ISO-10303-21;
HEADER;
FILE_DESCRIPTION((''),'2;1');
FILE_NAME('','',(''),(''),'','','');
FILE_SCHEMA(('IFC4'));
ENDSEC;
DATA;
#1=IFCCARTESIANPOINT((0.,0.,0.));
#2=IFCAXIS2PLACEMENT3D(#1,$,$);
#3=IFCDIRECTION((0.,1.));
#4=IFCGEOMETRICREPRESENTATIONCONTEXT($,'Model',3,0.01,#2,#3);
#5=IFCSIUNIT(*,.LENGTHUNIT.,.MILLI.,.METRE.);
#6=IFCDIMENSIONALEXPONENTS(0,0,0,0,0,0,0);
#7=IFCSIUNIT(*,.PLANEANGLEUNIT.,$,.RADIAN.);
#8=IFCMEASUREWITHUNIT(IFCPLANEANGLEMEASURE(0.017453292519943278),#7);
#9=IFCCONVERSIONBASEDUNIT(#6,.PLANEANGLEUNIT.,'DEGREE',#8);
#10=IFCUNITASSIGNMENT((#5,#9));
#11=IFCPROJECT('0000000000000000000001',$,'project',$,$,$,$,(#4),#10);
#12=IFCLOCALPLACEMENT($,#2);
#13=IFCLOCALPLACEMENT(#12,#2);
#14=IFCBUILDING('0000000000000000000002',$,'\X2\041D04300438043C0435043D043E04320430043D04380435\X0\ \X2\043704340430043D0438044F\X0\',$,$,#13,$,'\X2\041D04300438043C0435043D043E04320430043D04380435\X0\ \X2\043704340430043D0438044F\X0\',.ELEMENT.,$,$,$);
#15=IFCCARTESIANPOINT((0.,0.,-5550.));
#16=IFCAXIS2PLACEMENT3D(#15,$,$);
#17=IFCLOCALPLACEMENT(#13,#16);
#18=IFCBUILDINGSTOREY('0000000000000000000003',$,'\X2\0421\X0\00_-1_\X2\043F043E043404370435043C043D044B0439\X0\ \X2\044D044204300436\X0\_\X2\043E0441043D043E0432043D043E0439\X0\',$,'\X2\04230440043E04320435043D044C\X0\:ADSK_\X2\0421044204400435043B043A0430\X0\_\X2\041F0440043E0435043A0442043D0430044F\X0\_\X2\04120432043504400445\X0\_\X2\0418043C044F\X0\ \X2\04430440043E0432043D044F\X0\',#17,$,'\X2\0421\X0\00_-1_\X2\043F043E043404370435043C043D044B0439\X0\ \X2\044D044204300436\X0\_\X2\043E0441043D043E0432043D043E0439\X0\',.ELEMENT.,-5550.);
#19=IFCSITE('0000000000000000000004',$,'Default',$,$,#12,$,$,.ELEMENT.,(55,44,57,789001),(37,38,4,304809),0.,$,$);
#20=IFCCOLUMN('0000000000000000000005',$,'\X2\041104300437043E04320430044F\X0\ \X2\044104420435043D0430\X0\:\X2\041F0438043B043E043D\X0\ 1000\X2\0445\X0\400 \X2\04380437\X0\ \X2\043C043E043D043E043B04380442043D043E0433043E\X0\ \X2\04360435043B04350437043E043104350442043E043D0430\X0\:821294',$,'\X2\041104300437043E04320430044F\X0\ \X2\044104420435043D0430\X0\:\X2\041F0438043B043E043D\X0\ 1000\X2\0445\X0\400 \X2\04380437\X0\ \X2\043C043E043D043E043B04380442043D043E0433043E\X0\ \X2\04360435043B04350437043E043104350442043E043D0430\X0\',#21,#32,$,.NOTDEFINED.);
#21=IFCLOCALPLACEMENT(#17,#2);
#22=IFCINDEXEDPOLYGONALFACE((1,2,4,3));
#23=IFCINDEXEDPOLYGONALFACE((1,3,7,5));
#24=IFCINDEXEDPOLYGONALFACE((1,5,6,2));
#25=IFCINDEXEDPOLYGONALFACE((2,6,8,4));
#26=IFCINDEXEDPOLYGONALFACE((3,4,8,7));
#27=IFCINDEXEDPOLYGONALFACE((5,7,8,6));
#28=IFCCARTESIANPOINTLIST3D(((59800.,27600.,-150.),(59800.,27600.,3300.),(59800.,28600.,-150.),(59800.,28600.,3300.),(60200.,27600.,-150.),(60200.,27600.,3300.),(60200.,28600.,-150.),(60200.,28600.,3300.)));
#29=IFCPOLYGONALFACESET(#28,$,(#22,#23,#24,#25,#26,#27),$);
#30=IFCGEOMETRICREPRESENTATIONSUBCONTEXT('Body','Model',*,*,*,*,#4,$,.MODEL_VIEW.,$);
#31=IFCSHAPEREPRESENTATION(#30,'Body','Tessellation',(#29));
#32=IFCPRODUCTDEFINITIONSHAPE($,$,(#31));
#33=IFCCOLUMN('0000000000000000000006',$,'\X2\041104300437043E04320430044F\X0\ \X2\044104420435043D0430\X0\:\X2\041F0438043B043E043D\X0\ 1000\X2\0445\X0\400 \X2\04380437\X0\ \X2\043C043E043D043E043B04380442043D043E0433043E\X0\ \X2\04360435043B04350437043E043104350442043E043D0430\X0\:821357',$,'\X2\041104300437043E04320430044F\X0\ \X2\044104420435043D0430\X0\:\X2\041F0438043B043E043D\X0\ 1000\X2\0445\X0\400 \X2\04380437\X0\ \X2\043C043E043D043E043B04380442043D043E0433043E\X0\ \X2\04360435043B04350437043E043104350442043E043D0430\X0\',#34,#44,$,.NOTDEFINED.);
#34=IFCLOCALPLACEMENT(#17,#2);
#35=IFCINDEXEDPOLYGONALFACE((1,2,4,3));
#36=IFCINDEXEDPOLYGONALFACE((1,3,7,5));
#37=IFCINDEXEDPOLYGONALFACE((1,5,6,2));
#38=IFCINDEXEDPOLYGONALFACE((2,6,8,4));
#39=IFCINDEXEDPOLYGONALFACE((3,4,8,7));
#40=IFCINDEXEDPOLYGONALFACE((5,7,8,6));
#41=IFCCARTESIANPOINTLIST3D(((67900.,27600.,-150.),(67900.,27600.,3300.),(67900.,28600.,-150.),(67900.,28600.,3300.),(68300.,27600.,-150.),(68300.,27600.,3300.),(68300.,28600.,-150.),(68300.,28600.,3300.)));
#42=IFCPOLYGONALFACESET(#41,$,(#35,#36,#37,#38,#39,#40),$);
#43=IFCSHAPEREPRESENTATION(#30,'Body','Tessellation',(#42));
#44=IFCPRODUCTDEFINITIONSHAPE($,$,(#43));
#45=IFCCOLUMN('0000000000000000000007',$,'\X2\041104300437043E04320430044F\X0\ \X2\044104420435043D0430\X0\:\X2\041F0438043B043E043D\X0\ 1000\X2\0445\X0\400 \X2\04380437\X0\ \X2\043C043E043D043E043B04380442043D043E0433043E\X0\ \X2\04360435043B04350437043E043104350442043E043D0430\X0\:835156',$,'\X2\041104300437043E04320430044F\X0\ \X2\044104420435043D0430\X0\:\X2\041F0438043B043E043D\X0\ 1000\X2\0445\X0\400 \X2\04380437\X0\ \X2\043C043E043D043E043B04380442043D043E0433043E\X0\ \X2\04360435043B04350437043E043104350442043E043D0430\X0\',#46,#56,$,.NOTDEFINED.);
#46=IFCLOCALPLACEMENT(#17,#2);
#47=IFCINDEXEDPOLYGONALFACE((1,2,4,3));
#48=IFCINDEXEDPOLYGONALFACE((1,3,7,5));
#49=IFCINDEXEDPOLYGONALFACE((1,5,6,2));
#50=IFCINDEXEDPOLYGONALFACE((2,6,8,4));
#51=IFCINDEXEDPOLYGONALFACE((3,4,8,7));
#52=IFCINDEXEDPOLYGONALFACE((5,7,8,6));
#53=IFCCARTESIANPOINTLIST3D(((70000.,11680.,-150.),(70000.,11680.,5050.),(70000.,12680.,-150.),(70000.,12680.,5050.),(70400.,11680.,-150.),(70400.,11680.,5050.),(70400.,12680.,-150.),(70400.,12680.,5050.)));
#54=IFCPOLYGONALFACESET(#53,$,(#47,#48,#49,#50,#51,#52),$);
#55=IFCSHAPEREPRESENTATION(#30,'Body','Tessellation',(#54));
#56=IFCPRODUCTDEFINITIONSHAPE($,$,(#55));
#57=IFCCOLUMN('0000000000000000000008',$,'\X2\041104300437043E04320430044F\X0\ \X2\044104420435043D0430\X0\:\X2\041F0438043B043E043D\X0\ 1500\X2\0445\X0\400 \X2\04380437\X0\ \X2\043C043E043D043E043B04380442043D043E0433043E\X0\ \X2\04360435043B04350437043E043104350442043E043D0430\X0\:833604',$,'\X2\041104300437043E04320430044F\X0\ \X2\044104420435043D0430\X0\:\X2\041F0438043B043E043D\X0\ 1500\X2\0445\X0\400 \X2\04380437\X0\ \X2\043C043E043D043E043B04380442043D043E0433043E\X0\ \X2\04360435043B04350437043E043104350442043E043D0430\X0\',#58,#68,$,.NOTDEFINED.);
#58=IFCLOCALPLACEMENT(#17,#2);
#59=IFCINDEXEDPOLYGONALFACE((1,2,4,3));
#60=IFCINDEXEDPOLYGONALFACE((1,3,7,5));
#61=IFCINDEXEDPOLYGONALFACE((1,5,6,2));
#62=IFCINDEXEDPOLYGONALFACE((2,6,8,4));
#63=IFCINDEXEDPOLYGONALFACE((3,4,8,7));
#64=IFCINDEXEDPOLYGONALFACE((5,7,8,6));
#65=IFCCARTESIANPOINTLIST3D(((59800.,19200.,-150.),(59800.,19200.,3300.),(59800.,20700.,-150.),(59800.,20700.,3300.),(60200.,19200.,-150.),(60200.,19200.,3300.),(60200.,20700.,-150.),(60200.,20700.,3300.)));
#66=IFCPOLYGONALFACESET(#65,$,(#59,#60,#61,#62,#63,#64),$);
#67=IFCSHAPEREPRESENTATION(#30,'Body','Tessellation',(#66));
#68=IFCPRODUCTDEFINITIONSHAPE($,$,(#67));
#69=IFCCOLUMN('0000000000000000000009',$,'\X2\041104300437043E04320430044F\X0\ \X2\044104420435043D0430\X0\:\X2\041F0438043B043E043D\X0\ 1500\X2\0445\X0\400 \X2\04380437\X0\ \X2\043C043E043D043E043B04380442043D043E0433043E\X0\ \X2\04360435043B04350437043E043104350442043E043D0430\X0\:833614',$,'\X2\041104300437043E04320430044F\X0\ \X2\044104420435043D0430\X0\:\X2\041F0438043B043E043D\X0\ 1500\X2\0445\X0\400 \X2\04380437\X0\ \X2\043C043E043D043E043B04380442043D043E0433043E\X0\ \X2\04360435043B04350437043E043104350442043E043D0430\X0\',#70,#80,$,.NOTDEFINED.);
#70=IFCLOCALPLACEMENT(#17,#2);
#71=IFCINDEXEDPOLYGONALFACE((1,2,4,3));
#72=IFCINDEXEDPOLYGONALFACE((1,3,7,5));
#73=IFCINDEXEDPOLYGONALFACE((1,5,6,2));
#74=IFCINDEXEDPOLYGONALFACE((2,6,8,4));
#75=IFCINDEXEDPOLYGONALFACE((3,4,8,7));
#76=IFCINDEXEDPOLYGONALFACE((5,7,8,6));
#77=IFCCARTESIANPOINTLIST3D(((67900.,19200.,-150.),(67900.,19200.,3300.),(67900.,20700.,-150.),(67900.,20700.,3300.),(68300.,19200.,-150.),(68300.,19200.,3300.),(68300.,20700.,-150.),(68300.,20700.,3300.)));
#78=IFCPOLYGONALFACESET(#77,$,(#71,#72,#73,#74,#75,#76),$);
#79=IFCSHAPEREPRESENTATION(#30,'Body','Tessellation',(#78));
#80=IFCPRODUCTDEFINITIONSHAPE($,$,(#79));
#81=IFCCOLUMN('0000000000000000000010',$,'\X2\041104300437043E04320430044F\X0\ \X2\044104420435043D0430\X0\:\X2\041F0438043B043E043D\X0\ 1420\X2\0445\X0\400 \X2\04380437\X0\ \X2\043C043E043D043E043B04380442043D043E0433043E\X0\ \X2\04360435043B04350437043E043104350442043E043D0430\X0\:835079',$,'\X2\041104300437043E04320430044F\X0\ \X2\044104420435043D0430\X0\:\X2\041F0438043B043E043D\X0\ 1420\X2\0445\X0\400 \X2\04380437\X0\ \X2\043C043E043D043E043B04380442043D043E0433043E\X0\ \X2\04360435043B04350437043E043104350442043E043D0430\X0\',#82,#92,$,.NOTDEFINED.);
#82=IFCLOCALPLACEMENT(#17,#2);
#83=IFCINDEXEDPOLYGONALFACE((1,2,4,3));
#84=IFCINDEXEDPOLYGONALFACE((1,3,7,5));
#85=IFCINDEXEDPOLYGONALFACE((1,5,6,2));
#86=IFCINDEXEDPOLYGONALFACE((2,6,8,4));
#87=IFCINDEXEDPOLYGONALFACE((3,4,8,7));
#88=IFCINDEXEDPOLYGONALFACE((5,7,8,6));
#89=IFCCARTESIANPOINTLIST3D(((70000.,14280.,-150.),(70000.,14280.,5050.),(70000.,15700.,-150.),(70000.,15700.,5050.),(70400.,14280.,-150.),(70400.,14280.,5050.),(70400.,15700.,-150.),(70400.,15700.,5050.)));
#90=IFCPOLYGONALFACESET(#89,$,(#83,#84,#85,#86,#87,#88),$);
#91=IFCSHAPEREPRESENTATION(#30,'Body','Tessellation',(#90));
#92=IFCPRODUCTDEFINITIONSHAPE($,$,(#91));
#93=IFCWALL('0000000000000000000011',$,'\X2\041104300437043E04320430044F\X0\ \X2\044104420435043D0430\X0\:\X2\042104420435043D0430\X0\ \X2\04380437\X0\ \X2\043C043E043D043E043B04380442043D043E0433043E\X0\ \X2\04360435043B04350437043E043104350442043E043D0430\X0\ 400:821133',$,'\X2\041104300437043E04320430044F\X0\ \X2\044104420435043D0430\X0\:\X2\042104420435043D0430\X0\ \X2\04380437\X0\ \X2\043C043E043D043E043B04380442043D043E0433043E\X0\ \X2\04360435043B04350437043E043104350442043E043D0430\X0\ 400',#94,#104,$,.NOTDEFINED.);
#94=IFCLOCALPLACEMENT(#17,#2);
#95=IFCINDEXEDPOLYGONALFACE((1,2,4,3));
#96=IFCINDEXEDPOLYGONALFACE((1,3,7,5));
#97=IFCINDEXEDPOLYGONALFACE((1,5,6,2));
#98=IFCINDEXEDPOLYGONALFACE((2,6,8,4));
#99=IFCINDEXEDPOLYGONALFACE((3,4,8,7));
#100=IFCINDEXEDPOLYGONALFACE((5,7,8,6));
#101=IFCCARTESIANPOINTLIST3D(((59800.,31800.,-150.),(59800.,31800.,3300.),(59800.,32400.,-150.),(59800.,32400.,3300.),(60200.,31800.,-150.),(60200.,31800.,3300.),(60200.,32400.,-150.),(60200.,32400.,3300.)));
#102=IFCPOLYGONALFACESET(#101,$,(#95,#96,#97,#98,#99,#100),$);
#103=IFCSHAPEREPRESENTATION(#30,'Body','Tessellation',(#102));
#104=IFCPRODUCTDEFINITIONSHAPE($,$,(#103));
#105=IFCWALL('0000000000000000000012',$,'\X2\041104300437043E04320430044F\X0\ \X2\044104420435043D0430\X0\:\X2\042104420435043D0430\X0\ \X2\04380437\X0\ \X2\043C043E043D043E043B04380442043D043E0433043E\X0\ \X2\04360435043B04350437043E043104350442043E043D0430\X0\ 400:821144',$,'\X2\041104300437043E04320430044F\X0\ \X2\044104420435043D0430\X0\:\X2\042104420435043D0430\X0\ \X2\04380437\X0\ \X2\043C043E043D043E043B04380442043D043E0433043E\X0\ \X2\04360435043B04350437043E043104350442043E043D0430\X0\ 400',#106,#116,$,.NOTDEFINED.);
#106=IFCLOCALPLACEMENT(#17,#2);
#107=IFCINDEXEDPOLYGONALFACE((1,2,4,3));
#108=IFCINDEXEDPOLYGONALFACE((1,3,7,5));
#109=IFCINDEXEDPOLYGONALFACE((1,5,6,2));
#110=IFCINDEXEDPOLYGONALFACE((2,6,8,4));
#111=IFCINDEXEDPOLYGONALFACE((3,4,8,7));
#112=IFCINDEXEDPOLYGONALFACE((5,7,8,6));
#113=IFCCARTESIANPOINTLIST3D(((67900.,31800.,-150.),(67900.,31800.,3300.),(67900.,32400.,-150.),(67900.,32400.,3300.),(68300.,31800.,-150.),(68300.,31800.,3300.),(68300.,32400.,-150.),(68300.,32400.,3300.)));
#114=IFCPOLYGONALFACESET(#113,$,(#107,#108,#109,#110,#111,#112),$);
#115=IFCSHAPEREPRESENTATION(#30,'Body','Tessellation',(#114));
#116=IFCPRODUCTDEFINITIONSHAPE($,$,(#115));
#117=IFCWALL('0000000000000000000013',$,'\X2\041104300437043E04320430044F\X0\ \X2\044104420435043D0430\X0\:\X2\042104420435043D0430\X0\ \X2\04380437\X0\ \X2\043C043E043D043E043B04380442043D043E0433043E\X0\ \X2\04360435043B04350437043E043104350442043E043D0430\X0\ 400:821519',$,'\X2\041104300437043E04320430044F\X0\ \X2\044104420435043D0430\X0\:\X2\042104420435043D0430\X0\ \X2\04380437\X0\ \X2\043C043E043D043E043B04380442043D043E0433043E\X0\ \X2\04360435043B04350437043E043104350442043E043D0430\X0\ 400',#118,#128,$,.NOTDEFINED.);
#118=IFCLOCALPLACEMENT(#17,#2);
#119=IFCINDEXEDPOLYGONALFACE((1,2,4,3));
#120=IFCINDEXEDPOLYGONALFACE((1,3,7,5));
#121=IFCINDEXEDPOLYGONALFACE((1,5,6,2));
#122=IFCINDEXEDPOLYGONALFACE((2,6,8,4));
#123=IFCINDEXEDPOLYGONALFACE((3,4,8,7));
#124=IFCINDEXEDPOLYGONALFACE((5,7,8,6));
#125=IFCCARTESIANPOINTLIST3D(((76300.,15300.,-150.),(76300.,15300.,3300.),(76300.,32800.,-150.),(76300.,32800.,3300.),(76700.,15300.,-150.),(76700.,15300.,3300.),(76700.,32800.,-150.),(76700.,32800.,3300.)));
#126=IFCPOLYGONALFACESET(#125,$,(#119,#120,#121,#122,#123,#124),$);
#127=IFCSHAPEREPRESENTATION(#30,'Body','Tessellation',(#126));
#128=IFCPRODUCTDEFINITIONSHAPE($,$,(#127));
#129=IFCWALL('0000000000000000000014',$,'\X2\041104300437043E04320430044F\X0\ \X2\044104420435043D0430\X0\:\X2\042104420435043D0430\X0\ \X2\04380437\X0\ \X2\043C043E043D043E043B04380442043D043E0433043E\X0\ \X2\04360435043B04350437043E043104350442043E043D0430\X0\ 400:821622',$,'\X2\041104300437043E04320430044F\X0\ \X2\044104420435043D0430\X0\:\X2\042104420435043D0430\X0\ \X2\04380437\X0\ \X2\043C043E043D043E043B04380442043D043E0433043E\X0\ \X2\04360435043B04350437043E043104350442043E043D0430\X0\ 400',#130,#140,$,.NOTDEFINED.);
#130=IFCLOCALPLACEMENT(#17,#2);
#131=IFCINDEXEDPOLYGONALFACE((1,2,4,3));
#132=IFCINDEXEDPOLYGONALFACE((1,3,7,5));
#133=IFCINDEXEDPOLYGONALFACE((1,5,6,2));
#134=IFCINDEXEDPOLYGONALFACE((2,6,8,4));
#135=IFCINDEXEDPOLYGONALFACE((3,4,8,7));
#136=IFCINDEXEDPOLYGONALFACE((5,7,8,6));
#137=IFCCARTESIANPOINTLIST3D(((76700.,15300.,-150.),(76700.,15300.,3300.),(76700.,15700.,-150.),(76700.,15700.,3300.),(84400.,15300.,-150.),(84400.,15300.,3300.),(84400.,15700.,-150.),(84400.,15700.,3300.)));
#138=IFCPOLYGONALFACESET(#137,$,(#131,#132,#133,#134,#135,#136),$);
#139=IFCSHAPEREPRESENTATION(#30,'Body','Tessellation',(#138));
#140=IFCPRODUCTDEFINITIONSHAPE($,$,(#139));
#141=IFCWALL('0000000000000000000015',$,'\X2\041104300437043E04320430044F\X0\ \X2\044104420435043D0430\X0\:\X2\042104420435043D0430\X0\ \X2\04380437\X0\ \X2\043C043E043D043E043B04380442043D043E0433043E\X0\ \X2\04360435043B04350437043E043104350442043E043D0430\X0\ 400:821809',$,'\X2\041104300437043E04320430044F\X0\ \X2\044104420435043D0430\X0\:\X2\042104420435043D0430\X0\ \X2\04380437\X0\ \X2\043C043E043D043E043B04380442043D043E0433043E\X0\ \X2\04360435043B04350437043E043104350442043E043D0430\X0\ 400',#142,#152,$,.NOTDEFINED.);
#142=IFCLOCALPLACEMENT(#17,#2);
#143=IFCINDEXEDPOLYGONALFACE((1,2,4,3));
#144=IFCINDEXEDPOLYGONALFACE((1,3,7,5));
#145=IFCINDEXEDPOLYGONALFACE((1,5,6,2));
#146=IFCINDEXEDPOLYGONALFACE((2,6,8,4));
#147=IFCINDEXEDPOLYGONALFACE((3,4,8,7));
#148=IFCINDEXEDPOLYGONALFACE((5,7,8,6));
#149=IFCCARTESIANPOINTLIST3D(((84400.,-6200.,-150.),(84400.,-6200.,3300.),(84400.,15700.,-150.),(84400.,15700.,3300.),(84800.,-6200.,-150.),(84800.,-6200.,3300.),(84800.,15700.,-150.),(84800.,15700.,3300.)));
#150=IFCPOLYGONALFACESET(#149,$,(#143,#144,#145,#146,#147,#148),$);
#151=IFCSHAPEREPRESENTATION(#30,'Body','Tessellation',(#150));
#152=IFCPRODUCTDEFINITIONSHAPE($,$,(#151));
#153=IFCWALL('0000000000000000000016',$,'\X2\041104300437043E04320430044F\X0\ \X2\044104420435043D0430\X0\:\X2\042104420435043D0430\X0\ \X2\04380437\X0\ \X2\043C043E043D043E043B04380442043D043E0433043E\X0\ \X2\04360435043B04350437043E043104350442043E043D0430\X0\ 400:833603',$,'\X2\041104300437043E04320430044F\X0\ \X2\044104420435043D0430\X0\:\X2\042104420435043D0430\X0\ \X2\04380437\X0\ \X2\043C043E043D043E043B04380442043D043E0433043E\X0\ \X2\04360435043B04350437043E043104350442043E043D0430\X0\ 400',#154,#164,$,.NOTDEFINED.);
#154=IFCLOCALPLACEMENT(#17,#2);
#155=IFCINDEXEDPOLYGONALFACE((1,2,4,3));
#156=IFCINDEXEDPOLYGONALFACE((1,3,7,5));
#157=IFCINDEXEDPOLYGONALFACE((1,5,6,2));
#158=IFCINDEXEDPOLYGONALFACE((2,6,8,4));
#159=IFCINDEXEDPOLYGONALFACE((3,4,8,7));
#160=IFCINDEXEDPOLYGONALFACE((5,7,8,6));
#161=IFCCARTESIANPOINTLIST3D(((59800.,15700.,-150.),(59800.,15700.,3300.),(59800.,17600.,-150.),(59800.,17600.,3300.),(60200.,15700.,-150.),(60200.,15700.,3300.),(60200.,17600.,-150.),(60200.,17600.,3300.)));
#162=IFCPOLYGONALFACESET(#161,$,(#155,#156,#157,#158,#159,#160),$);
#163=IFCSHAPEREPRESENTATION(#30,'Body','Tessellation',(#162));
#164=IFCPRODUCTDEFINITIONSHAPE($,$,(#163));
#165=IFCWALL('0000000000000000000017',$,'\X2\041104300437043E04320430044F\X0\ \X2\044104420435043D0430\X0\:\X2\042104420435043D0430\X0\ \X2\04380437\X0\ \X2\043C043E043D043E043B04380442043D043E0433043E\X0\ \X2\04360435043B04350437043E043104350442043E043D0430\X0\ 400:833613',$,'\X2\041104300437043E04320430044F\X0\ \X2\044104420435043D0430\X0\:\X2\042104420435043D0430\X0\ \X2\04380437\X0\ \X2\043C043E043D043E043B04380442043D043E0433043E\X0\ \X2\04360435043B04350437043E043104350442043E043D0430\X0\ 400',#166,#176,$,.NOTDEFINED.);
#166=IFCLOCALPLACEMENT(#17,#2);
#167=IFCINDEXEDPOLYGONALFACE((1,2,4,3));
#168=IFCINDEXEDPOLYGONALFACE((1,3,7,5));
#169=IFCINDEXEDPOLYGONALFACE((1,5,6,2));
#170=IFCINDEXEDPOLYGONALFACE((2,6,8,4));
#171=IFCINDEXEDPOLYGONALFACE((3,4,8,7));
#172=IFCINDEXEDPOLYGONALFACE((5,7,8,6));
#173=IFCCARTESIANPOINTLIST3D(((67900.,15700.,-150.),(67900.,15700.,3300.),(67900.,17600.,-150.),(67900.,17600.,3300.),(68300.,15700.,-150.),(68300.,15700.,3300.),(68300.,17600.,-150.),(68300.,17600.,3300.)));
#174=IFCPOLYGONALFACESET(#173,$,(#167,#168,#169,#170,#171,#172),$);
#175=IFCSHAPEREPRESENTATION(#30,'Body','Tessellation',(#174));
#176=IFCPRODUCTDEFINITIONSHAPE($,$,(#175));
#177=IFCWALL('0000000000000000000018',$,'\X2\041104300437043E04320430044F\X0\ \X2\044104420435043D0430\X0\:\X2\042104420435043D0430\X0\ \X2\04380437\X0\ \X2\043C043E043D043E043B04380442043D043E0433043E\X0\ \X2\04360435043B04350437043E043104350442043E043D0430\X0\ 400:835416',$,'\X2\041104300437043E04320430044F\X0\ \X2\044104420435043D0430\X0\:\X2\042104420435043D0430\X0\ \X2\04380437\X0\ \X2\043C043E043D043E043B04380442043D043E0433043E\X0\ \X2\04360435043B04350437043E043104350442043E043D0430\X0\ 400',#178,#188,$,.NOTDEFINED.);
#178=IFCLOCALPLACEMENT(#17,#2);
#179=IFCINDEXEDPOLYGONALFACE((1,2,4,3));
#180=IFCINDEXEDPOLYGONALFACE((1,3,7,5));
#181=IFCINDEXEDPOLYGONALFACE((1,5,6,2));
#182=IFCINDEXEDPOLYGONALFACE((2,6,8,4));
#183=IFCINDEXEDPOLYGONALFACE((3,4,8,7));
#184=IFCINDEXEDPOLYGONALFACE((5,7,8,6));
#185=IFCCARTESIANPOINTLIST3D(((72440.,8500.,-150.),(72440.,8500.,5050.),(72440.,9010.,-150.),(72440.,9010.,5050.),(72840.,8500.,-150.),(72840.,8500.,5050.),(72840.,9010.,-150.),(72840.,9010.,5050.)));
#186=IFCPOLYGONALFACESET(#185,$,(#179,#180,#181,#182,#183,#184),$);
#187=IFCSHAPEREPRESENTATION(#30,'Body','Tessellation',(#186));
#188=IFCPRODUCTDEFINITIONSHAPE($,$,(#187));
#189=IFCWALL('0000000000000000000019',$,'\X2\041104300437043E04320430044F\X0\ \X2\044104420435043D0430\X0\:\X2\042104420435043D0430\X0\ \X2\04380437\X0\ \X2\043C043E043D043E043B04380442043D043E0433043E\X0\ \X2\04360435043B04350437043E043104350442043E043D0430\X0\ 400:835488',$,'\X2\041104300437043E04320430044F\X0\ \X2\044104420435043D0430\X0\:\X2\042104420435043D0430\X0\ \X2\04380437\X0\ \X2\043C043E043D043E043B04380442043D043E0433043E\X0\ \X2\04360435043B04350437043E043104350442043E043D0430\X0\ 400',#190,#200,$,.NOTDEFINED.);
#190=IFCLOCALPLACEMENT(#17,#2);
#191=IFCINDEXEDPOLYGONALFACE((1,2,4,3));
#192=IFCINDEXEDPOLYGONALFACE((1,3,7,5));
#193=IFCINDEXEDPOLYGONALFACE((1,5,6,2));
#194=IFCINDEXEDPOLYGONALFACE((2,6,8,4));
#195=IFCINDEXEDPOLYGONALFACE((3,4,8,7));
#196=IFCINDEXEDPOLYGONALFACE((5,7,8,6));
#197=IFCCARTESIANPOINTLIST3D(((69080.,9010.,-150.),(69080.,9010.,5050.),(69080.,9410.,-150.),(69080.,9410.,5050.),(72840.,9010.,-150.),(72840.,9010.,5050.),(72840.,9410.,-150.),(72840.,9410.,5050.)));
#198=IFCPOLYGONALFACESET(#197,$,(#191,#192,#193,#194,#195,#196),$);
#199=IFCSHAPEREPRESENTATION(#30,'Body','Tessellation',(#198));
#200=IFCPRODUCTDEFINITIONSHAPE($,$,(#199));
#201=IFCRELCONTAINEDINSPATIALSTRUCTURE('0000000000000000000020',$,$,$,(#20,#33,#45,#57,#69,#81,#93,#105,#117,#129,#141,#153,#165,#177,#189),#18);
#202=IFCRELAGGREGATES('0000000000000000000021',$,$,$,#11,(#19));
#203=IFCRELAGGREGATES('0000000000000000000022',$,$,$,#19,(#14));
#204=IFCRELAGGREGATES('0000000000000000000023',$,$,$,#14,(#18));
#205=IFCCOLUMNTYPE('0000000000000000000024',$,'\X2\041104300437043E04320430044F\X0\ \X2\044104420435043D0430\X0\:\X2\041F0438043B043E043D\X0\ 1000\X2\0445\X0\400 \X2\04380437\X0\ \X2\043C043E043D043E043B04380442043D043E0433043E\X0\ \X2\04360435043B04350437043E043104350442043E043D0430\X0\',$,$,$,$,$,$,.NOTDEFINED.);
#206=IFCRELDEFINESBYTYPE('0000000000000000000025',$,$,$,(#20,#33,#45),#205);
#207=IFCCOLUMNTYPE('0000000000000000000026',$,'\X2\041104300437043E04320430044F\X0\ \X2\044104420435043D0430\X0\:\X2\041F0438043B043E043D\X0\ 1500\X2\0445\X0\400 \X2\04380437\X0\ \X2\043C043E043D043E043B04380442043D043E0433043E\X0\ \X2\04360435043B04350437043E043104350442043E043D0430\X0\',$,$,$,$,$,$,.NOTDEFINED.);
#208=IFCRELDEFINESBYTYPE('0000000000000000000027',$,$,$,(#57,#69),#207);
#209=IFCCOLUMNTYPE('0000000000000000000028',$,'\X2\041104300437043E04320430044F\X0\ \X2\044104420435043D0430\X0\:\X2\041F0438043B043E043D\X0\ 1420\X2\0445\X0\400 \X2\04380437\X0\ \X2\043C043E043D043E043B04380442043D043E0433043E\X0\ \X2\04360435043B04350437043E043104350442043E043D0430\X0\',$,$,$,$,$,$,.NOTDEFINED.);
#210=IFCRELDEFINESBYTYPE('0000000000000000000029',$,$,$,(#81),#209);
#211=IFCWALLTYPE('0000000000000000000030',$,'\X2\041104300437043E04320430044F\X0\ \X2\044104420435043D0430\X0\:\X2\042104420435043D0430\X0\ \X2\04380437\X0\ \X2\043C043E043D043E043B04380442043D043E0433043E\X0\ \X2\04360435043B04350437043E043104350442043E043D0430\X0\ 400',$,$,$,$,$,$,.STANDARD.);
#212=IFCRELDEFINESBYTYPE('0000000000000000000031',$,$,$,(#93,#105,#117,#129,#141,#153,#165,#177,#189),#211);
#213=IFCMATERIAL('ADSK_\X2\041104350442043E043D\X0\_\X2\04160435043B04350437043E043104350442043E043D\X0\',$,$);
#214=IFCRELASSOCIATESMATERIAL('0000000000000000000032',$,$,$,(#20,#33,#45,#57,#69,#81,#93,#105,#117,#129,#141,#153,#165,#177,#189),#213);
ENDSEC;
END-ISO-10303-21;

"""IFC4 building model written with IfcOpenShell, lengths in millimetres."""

from ifc_helpers import new_model, entity, si_unit, converted_unit, direction, frame, origin, place, context, subcontext, project, spatial, indexed_curve, outline, extrude, material, type_object, element, save


model = new_model("IFC4")

# Units and contexts
model_context = context("Model", 3, precision=0.01, world=origin(), true_north=direction((0.0, 1.0)))
body_context = subcontext(model_context, "Body", "Model", "MODEL_VIEW")
ifc_project = project(units=[si_unit("LENGTHUNIT", "METRE", prefix="MILLI"), converted_unit("PLANEANGLEUNIT", "DEGREE", entity("IfcPlaneAngleMeasure", 0.017453292519943278), si_unit("PLANEANGLEUNIT", "RADIAN"), dimensions=[0, 0, 0, 0, 0, 0, 0])], contexts=[model_context])

# Site, building, storey
site_placement = place(None, origin())
site = spatial("IfcSite", under=ifc_project, at=site_placement, Name="Default", CompositionType="ELEMENT", RefLatitude=(55, 44, 57, 789001), RefLongitude=(37, 38, 4, 304809), RefElevation=0.0)
building_placement = place(site_placement, origin())
building = spatial("IfcBuilding", under=site, at=building_placement, Name="Наименование здания", LongName="Наименование здания", CompositionType="ELEMENT")
storey_placement = place(building_placement, frame((0.0, 0.0, -5550.0)))
storey = spatial("IfcBuildingStorey", under=building, at=storey_placement, Name="С00_-1_подземный этаж_основной", ObjectType="Уровень:ADSK_Стрелка_Проектная_Вверх_Имя уровня", LongName="С00_-1_подземный этаж_основной", CompositionType="ELEMENT", Elevation=-5550.0)

# Columns
ifc_material_1 = material(Name="ADSK_Бетон_Железобетон")
column_type_1 = type_object("IfcColumnType", Name="Базовая стена:Пилон 1000х400 из монолитного железобетона", PredefinedType="NOTDEFINED")
for number, where, z_axis, x_axis, name in (
    (1, (60000.0, 27600.0, -150.0), (0.0, 0.0, 1.0), (0.0, 1.0, 0.0), "Базовая стена:Пилон 1000х400 из монолитного железобетона:821294"),
    (2, (68100.0, 27600.0, -150.0), (0.0, 0.0, 1.0), (0.0, 1.0, 0.0), "Базовая стена:Пилон 1000х400 из монолитного железобетона:821357"),
):
    element("IfcColumn", number, at=place(storey_placement, frame(where, z_axis=z_axis, x_axis=x_axis)), inside=storey, type_object=column_type_1, material=ifc_material_1, Name=name, ObjectType="Базовая стена:Пилон 1000х400 из монолитного железобетона", PredefinedType="NOTDEFINED", context=body_context, shape_type="SweptSolid", body=[
        extrude(outline(indexed_curve([(1000.0, 200.0), (0.0, 200.0), (0.0, -200.0), (1000.0, -200.0), (1000.0, 200.0)], self_intersect=False)), origin(), (0.0, 0.0, 1.0), 3450.0),
    ])
column_1_placement = place(storey_placement, frame((70200.0, 12680.0, -150.0), z_axis=(0.0, 0.0, 1.0), x_axis=(0.0, -1.0, 0.0)))
element("IfcColumn", 3, at=column_1_placement, inside=storey, type_object=column_type_1, material=ifc_material_1, Name="Базовая стена:Пилон 1000х400 из монолитного железобетона:835156", ObjectType="Базовая стена:Пилон 1000х400 из монолитного железобетона", PredefinedType="NOTDEFINED", context=body_context, shape_type="SweptSolid", body=[
    extrude(outline(indexed_curve([(1000.0, 200.0), (0.0, 200.0), (0.0, -200.0), (1000.0, -200.0), (1000.0, 200.0)], self_intersect=False)), origin(), (0.0, 0.0, 1.0), 5200.0),
])
column_type_2 = type_object("IfcColumnType", Name="Базовая стена:Пилон 1500х400 из монолитного железобетона", PredefinedType="NOTDEFINED")
for number, where, z_axis, x_axis, name in (
    (4, (60000.0, 19200.0, -150.0), (0.0, 0.0, 1.0), (0.0, 1.0, 0.0), "Базовая стена:Пилон 1500х400 из монолитного железобетона:833604"),
    (5, (68100.0, 19200.0, -150.0), (0.0, 0.0, 1.0), (0.0, 1.0, 0.0), "Базовая стена:Пилон 1500х400 из монолитного железобетона:833614"),
):
    element("IfcColumn", number, at=place(storey_placement, frame(where, z_axis=z_axis, x_axis=x_axis)), inside=storey, type_object=column_type_2, material=ifc_material_1, Name=name, ObjectType="Базовая стена:Пилон 1500х400 из монолитного железобетона", PredefinedType="NOTDEFINED", context=body_context, shape_type="SweptSolid", body=[
        extrude(outline(indexed_curve([(1500.0, 200.0), (0.0, 200.0), (0.0, -200.0), (1500.0, -200.0), (1500.0, 200.0)], self_intersect=False)), origin(), (0.0, 0.0, 1.0), 3450.0),
    ])
column_type_3 = type_object("IfcColumnType", Name="Базовая стена:Пилон 1420х400 из монолитного железобетона", PredefinedType="NOTDEFINED")
column_2_placement = place(storey_placement, frame((70200.0, 15700.0, -150.0), z_axis=(0.0, 0.0, 1.0), x_axis=(0.0, -1.0, 0.0)))
element("IfcColumn", 6, at=column_2_placement, inside=storey, type_object=column_type_3, material=ifc_material_1, Name="Базовая стена:Пилон 1420х400 из монолитного железобетона:835079", ObjectType="Базовая стена:Пилон 1420х400 из монолитного железобетона", PredefinedType="NOTDEFINED", context=body_context, shape_type="SweptSolid", body=[
    extrude(outline(indexed_curve([(1420.0, 200.0), (0.0, 200.0), (0.0, -200.0), (1420.0, -200.0), (1420.0, 200.0)], self_intersect=False)), origin(), (0.0, 0.0, 1.0), 5200.0),
])

# Walls
wall_type_1 = type_object("IfcWallType", Name="Базовая стена:Стена из монолитного железобетона 400", PredefinedType="STANDARD")
for number, where, z_axis, x_axis, name in (
    (7, (60000.0, 31800.0, -150.0), (0.0, 0.0, 1.0), (0.0, 1.0, 0.0), "Базовая стена:Стена из монолитного железобетона 400:821133"),
    (8, (68100.0, 31800.0, -150.0), (0.0, 0.0, 1.0), (0.0, 1.0, 0.0), "Базовая стена:Стена из монолитного железобетона 400:821144"),
):
    element("IfcWall", number, at=place(storey_placement, frame(where, z_axis=z_axis, x_axis=x_axis)), inside=storey, type_object=wall_type_1, material=ifc_material_1, Name=name, ObjectType="Базовая стена:Стена из монолитного железобетона 400", PredefinedType="NOTDEFINED", context=body_context, shape_type="SweptSolid", body=[
        extrude(outline(indexed_curve([(600.0, 200.0), (0.0, 200.0), (0.0, -200.0), (600.0, -200.0), (600.0, 200.0)], self_intersect=False)), origin(), (0.0, 0.0, 1.0), 3450.0),
    ])
wall_1_placement = place(storey_placement, frame((76500.0, 32800.0, -150.0), z_axis=(0.0, 0.0, 1.0), x_axis=(0.0, -1.0, 0.0)))
element("IfcWall", 9, at=wall_1_placement, inside=storey, type_object=wall_type_1, material=ifc_material_1, Name="Базовая стена:Стена из монолитного железобетона 400:821519", ObjectType="Базовая стена:Стена из монолитного железобетона 400", PredefinedType="NOTDEFINED", context=body_context, shape_type="SweptSolid", body=[
    extrude(outline(indexed_curve([(17500.0, 200.0), (0.0, 200.0), (0.0, -200.0), (17500.0, -200.0), (17500.0, 200.0)], self_intersect=False)), origin(), (0.0, 0.0, 1.0), 3450.0),
])
wall_2_placement = place(storey_placement, frame((76700.0, 15500.0, -150.0)))
element("IfcWall", 10, at=wall_2_placement, inside=storey, type_object=wall_type_1, material=ifc_material_1, Name="Базовая стена:Стена из монолитного железобетона 400:821622", ObjectType="Базовая стена:Стена из монолитного железобетона 400", PredefinedType="NOTDEFINED", context=body_context, shape_type="SweptSolid", body=[
    extrude(outline(indexed_curve([(7700.0, 200.0), (0.0, 200.0), (0.0, -200.0), (7700.0, -200.0), (7700.0, 200.0)], self_intersect=False)), origin(), (0.0, 0.0, 1.0), 3450.0),
])
wall_3_placement = place(storey_placement, frame((84600.0, 15700.0, -150.0), z_axis=(0.0, 0.0, 1.0), x_axis=(0.0, -1.0, 0.0)))
element("IfcWall", 11, at=wall_3_placement, inside=storey, type_object=wall_type_1, material=ifc_material_1, Name="Базовая стена:Стена из монолитного железобетона 400:821809", ObjectType="Базовая стена:Стена из монолитного железобетона 400", PredefinedType="NOTDEFINED", context=body_context, shape_type="SweptSolid", body=[
    extrude(outline(indexed_curve([(21900.0, 200.0), (0.0, 200.0), (0.0, -200.0), (21900.0, -200.0), (21900.0, 200.0)], self_intersect=False)), origin(), (0.0, 0.0, 1.0), 3450.0),
])
wall_4_placement = place(storey_placement, frame((60000.0, 15700.0, -150.0), z_axis=(0.0, 0.0, 1.0), x_axis=(0.0, 1.0, 0.0)))
element("IfcWall", 12, at=wall_4_placement, inside=storey, type_object=wall_type_1, material=ifc_material_1, Name="Базовая стена:Стена из монолитного железобетона 400:833603", ObjectType="Базовая стена:Стена из монолитного железобетона 400", PredefinedType="NOTDEFINED", context=body_context, shape_type="SweptSolid", body=[
    extrude(outline(indexed_curve([(1900.0, 200.0), (0.0, 200.0), (0.0, -200.0), (1900.0, -200.0), (1900.0, 200.0)], self_intersect=False)), origin(), (0.0, 0.0, 1.0), 3450.0),
])
wall_5_placement = place(storey_placement, frame((68100.0, 15700.0, -150.0), z_axis=(0.0, 0.0, 1.0), x_axis=(0.0, 1.0, 0.0)))
element("IfcWall", 13, at=wall_5_placement, inside=storey, type_object=wall_type_1, material=ifc_material_1, Name="Базовая стена:Стена из монолитного железобетона 400:833613", ObjectType="Базовая стена:Стена из монолитного железобетона 400", PredefinedType="NOTDEFINED", context=body_context, shape_type="SweptSolid", body=[
    extrude(outline(indexed_curve([(1900.0, 200.0), (0.0, 200.0), (0.0, -200.0), (1900.0, -200.0), (1900.0, 200.0)], self_intersect=False)), origin(), (0.0, 0.0, 1.0), 3450.0),
])
wall_6_placement = place(storey_placement, frame((72640.0, 8500.0, -150.0), z_axis=(0.0, 0.0, 1.0), x_axis=(0.0, 1.0, 0.0)))
element("IfcWall", 14, at=wall_6_placement, inside=storey, type_object=wall_type_1, material=ifc_material_1, Name="Базовая стена:Стена из монолитного железобетона 400:835416", ObjectType="Базовая стена:Стена из монолитного железобетона 400", PredefinedType="NOTDEFINED", context=body_context, shape_type="SweptSolid", body=[
    extrude(outline(indexed_curve([(510.0, 200.0), (0.0, 200.0), (0.0, -200.0), (510.0, -200.0), (510.0, 200.0)], self_intersect=False)), origin(), (0.0, 0.0, 1.0), 5200.0),
])
wall_7_placement = place(storey_placement, frame((69080.0, 9210.0, -150.0)))
element("IfcWall", 15, at=wall_7_placement, inside=storey, type_object=wall_type_1, material=ifc_material_1, Name="Базовая стена:Стена из монолитного железобетона 400:835488", ObjectType="Базовая стена:Стена из монолитного железобетона 400", PredefinedType="NOTDEFINED", context=body_context, shape_type="SweptSolid", body=[
    extrude(outline(indexed_curve([(3760.0, 200.0), (0.0, 200.0), (0.0, -200.0), (3760.0, -200.0), (3760.0, 200.0)], self_intersect=False)), origin(), (0.0, 0.0, 1.0), 5200.0),
])

save(model, "model.ifc")
